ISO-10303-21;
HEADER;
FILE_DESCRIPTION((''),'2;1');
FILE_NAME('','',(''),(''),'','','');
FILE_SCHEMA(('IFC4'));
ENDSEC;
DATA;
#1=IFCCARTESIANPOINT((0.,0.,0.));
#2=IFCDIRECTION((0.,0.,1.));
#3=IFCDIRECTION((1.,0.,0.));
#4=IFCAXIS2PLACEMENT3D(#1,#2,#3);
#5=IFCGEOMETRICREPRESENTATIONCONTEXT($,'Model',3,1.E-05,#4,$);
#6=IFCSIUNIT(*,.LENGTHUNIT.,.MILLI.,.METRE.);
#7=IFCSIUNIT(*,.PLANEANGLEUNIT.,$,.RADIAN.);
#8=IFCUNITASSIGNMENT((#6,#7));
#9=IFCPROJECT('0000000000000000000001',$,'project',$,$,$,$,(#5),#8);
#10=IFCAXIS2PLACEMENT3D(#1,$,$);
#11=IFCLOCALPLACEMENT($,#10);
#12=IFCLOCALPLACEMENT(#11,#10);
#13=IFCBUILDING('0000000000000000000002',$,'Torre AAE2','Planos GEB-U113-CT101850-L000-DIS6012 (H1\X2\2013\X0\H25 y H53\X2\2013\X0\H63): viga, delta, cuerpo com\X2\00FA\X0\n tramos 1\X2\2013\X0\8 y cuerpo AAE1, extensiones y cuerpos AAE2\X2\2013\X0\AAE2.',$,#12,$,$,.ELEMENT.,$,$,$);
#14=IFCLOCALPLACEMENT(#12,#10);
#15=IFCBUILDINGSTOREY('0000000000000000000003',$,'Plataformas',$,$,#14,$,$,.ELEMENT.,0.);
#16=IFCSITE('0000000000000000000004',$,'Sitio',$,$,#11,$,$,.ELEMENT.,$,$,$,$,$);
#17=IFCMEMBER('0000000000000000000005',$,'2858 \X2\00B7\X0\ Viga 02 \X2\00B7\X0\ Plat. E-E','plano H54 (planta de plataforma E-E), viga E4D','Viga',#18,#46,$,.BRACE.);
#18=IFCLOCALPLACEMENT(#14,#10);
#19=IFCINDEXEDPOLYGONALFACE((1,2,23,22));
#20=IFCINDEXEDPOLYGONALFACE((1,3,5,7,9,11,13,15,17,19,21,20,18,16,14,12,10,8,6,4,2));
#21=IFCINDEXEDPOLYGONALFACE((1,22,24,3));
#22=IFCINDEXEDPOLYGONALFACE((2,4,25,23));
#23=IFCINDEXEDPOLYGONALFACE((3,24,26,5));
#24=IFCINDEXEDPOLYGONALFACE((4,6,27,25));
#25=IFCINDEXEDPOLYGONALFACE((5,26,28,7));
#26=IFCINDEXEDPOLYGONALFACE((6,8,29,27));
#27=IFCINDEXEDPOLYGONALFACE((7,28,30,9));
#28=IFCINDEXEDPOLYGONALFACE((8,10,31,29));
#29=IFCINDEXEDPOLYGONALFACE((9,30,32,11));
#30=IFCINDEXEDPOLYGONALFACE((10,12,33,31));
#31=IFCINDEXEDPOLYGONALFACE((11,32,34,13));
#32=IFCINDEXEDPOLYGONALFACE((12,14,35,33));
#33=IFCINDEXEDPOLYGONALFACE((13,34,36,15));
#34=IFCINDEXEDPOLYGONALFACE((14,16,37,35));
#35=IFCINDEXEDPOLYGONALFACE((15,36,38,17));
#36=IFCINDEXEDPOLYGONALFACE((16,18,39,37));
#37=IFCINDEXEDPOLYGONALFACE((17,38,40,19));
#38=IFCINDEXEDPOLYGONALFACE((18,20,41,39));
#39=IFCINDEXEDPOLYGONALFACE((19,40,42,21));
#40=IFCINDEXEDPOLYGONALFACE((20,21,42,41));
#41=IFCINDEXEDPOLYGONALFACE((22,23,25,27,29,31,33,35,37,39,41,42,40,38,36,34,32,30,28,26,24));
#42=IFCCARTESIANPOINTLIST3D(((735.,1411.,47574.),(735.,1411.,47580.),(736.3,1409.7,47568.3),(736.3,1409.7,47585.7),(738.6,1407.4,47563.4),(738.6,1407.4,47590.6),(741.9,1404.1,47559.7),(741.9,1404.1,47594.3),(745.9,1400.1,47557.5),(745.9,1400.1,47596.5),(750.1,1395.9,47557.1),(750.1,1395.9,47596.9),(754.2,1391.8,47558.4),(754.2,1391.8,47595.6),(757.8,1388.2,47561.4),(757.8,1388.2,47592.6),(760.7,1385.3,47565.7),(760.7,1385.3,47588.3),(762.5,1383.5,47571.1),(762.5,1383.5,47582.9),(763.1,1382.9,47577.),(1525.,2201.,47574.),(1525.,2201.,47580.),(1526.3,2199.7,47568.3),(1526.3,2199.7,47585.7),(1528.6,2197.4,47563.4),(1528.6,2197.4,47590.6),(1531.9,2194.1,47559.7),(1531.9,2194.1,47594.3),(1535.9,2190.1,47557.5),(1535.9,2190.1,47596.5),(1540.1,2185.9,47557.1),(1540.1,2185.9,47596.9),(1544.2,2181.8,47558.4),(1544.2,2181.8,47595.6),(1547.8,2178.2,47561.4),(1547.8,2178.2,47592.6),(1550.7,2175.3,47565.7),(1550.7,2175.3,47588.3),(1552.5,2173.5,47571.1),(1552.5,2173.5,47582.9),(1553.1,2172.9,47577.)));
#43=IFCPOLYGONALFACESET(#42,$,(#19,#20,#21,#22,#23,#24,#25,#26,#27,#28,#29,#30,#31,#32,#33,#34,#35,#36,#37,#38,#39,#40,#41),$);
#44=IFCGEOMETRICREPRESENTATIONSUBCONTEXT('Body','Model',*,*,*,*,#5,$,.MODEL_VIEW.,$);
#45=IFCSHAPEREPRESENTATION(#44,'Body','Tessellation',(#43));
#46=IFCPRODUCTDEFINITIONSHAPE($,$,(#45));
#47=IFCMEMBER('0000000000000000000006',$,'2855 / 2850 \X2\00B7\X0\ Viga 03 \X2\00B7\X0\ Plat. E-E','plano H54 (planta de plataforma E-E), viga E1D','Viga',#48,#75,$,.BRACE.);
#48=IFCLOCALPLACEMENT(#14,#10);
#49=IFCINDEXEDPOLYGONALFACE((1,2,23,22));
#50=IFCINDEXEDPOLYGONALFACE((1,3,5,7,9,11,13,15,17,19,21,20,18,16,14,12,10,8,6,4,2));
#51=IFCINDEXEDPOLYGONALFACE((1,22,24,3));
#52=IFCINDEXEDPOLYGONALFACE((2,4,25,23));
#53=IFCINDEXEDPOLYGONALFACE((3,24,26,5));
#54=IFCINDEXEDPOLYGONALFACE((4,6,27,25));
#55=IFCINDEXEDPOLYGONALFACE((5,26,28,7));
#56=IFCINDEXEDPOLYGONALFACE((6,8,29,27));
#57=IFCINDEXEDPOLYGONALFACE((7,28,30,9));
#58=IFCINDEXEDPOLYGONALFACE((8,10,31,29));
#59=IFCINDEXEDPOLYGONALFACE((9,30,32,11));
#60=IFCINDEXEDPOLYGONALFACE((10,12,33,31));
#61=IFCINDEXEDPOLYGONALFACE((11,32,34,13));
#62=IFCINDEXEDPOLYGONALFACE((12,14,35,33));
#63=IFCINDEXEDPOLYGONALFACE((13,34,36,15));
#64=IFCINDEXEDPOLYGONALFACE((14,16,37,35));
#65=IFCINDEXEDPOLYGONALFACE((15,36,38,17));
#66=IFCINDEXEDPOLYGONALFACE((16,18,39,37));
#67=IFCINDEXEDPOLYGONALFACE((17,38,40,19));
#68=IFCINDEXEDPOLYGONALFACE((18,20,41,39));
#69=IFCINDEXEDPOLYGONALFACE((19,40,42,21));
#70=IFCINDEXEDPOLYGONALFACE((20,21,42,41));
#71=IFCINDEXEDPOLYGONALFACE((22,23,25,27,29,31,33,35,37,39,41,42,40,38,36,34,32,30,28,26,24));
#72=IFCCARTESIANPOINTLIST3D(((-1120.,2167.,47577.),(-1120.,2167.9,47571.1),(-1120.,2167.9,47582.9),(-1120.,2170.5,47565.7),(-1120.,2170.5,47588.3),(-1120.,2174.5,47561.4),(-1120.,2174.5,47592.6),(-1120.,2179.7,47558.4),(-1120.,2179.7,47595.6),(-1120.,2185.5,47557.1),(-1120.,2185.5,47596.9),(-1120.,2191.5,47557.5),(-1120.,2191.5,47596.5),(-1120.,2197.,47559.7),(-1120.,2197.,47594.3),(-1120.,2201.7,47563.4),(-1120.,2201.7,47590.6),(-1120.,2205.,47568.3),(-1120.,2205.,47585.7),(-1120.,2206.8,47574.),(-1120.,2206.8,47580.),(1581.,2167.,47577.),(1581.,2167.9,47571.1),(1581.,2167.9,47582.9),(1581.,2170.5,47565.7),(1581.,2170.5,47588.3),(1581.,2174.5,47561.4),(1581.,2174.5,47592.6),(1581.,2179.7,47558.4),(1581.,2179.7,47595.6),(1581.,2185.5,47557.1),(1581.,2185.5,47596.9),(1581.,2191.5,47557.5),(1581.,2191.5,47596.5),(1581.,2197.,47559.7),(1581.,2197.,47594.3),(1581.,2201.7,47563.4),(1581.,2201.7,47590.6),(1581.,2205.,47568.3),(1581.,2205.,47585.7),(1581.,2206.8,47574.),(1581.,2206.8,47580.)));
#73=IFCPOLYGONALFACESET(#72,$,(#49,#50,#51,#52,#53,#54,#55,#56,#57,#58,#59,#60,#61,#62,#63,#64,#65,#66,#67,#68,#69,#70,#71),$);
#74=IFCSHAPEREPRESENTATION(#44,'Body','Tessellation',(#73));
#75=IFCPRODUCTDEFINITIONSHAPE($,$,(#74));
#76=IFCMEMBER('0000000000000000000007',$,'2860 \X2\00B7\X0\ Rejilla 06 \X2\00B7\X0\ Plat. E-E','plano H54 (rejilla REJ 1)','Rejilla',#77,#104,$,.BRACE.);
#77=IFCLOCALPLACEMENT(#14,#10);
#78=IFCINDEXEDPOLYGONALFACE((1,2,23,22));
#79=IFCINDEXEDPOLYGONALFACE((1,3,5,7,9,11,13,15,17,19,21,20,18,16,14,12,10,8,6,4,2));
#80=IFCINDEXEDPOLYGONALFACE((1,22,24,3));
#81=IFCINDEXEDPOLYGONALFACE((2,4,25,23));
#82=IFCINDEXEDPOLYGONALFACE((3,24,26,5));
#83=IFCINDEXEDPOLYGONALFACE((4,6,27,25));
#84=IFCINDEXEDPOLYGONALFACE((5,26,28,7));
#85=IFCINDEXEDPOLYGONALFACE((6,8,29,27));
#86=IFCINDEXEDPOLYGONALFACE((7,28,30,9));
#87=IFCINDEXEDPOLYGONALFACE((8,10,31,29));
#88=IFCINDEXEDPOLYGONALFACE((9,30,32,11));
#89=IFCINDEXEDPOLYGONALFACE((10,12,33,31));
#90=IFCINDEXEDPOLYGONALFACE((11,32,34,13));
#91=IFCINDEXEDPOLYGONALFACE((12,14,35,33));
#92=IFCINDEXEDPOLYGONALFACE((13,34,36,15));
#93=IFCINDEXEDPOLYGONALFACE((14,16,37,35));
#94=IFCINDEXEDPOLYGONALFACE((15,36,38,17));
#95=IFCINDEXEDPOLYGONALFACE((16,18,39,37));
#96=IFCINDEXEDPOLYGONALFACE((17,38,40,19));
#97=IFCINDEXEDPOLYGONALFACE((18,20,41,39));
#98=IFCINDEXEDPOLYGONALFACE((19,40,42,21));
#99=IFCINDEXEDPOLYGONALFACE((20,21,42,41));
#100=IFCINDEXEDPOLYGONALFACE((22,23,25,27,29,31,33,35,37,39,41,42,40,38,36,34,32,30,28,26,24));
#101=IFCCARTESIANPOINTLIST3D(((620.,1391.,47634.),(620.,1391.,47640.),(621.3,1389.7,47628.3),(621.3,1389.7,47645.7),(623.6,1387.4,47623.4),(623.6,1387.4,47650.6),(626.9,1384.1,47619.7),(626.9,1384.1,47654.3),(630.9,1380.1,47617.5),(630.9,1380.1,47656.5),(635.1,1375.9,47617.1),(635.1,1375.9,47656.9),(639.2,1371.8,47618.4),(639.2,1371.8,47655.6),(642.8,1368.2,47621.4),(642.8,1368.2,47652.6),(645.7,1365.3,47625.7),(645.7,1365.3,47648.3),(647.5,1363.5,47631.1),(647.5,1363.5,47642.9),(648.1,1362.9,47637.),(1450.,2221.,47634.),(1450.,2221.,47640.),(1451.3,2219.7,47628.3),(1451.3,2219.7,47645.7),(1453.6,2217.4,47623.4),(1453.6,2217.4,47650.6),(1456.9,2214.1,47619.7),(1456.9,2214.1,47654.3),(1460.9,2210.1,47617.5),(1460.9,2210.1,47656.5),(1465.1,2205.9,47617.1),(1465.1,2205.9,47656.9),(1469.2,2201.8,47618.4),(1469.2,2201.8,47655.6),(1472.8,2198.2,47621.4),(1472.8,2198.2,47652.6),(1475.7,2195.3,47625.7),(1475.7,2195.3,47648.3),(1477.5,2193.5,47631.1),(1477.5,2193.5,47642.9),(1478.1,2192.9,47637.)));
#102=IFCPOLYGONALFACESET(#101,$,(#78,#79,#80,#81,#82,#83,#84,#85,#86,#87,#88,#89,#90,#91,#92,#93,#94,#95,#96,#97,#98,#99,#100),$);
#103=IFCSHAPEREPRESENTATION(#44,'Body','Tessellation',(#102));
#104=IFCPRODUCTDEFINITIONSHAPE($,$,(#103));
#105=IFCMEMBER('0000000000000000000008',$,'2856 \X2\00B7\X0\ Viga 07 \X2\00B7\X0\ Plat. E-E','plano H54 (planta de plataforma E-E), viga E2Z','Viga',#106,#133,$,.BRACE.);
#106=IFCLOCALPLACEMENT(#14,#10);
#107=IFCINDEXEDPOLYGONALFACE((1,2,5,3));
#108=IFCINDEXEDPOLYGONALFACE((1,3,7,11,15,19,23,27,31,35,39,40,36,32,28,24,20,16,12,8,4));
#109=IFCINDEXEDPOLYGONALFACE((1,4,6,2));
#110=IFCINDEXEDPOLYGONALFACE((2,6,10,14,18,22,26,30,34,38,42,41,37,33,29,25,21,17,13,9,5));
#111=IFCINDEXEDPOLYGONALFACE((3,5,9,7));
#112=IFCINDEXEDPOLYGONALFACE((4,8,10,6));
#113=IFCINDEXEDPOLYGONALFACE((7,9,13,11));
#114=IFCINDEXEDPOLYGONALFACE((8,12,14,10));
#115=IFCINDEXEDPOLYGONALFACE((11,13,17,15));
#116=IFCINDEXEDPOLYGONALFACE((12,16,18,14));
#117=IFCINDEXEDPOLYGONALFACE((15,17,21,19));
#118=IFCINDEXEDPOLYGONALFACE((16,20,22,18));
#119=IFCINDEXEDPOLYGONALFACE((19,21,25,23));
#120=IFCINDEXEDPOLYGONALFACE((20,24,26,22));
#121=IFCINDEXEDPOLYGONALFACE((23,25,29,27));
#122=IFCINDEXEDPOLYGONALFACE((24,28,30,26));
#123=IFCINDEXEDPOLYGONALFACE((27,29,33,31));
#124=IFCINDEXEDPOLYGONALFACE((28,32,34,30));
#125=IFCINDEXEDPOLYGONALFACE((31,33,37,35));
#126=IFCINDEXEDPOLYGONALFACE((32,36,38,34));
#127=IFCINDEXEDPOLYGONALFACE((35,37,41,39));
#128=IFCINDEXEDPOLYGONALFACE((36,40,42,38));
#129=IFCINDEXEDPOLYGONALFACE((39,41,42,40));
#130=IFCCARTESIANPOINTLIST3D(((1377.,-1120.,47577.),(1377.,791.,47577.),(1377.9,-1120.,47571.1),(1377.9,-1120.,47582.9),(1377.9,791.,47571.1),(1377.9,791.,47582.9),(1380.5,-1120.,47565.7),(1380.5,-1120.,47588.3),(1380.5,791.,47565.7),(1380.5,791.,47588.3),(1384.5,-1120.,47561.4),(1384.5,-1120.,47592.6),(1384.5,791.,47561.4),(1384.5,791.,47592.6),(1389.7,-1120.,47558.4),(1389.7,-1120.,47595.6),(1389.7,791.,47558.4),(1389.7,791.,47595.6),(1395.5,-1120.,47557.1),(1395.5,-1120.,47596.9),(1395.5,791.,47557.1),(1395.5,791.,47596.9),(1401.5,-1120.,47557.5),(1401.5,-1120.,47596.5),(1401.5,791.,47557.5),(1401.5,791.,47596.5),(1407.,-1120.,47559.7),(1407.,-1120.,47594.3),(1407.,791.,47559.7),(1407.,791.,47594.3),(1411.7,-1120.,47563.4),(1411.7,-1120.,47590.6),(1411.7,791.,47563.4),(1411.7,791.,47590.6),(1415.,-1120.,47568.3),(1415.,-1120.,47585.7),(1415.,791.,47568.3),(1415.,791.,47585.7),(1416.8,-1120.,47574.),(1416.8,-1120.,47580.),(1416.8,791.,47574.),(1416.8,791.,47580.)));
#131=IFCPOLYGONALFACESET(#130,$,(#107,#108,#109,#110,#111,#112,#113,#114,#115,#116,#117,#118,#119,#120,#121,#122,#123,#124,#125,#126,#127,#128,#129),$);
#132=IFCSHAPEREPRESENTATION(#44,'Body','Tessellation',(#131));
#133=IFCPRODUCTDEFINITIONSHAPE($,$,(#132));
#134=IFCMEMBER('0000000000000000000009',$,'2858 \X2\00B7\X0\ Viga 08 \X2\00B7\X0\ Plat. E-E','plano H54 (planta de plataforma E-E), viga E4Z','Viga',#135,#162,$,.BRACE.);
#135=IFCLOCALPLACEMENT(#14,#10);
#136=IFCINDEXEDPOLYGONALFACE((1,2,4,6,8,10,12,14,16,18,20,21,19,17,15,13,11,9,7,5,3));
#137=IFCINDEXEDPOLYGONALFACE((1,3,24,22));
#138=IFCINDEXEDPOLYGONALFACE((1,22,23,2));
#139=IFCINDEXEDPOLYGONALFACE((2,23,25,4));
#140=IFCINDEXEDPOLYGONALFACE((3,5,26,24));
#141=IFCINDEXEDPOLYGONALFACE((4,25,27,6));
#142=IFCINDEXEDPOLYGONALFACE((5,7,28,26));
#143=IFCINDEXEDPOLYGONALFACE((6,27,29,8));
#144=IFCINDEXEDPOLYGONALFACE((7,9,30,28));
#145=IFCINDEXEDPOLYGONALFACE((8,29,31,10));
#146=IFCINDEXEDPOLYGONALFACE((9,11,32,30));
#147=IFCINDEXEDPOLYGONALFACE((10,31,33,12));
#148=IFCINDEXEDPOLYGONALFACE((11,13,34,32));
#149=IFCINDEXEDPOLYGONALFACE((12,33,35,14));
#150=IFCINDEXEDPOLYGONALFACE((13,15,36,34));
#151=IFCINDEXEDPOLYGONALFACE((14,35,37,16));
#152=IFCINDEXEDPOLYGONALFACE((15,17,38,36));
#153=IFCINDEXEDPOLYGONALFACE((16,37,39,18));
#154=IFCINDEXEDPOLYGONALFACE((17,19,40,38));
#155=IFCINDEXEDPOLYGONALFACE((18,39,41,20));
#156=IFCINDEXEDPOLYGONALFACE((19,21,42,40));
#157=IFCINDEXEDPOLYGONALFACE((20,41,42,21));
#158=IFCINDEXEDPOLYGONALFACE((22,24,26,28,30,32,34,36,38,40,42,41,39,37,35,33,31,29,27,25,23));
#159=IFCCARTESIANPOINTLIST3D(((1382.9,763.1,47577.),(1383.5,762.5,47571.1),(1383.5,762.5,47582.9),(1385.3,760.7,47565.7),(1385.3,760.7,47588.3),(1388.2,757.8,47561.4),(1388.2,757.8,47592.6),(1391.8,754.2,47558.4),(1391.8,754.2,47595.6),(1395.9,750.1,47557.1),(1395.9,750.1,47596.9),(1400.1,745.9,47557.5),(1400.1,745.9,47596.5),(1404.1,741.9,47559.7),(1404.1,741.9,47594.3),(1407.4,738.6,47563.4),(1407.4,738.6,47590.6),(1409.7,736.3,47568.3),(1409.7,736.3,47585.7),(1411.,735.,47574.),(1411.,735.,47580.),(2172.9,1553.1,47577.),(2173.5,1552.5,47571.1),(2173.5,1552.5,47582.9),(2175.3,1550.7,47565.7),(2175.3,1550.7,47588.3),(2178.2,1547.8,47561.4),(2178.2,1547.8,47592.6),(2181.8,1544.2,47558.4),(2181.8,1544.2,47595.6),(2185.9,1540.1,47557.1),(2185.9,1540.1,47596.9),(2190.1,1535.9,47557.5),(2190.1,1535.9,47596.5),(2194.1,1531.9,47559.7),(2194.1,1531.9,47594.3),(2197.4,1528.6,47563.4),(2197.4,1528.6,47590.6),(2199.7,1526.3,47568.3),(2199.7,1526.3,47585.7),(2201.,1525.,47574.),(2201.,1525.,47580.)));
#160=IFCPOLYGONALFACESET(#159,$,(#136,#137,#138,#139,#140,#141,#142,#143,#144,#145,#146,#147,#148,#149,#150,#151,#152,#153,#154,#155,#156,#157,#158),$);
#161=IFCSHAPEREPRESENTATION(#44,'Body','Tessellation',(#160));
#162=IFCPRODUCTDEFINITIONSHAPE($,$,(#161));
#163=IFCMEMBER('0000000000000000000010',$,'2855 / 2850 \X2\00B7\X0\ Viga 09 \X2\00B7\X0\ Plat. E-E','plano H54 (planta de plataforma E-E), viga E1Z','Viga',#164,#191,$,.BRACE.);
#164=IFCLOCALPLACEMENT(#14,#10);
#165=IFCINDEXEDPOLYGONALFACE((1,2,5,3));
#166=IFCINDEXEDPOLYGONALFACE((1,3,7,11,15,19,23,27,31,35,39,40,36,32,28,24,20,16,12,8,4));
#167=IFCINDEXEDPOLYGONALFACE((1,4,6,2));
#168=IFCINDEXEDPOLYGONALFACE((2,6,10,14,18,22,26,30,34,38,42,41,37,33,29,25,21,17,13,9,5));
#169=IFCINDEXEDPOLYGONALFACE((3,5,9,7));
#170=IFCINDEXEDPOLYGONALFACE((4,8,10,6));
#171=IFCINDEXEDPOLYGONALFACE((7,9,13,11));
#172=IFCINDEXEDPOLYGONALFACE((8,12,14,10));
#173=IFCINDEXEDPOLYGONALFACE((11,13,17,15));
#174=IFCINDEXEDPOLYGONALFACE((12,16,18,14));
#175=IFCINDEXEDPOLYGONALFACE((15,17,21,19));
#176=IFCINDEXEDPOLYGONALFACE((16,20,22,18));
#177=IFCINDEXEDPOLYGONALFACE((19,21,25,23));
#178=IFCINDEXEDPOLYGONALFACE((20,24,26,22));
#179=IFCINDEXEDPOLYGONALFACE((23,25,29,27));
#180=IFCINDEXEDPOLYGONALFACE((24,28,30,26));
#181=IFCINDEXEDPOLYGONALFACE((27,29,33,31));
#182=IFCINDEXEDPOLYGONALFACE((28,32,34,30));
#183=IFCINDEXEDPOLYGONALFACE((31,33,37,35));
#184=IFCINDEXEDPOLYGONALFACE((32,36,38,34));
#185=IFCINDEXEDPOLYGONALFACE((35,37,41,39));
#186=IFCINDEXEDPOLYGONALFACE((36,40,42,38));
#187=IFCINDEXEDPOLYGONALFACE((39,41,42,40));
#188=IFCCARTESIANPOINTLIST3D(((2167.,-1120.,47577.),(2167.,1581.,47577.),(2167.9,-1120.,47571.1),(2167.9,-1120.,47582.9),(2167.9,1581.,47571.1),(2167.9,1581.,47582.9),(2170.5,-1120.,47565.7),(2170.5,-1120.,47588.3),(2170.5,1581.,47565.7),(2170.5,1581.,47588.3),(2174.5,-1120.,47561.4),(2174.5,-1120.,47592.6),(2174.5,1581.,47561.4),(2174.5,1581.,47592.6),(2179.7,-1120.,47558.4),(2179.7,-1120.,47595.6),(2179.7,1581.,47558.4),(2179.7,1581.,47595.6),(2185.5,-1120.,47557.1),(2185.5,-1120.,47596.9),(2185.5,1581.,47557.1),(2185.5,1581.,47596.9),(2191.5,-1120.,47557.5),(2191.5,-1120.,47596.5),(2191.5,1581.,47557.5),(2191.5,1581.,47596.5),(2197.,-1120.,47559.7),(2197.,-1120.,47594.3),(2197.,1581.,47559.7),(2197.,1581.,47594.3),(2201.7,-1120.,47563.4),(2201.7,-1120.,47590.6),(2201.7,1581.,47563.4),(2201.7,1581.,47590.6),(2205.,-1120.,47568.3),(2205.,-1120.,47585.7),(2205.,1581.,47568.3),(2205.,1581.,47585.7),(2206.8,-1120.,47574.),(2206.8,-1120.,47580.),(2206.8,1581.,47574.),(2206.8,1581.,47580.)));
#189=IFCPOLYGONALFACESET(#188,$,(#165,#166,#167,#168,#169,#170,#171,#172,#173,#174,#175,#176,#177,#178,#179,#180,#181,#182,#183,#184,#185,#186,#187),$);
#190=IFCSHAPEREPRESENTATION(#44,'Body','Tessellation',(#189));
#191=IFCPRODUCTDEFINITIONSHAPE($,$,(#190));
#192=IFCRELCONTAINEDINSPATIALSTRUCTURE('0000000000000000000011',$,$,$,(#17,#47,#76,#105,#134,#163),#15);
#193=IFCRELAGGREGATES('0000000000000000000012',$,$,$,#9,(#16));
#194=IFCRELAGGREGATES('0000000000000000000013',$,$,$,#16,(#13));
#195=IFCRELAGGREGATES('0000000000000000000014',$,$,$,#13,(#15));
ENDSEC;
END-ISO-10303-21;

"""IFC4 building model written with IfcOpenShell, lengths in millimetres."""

from ifc_helpers import new_model, si_unit, frame, origin, origin_with_axes, place, context, subcontext, project, spatial, circle, extrude, element, save


model = new_model("IFC4")

# Units and contexts
model_context = context("Model", 3, precision=1e-05, world=origin_with_axes())
body_context = subcontext(model_context, "Body", "Model", "MODEL_VIEW")
ifc_project = project(units=[si_unit("LENGTHUNIT", "METRE", prefix="MILLI"), si_unit("PLANEANGLEUNIT", "RADIAN")], contexts=[model_context])

# Site, building, storey
site_placement = place(None, origin())
site = spatial("IfcSite", under=ifc_project, at=site_placement, Name="Sitio", CompositionType="ELEMENT")
building_placement = place(site_placement, origin())
building = spatial("IfcBuilding", under=site, at=building_placement, Name="Torre AAE2", Description="Planos GEB-U113-CT101850-L000-DIS6012 (H1–H25 y H53–H63): viga, delta, cuerpo común tramos 1–8 y cuerpo AAE1, extensiones y cuerpos AAE2–AAE2.", CompositionType="ELEMENT")
storey_placement = place(building_placement, origin())
storey = spatial("IfcBuildingStorey", under=building, at=storey_placement, Name="Plataformas", CompositionType="ELEMENT", Elevation=0.0)

# Members
member_1_placement = place(storey_placement, frame((1539.0, 2187.0, 47577.0), z_axis=(-0.707107, -0.707107, 0.0), x_axis=(0.707107, -0.707107, 0.0)))
element("IfcMember", 1, at=member_1_placement, inside=storey, Name="2858 · Viga 02 · Plat. E-E", Description="plano H54 (planta de plataforma E-E), viga E4D", ObjectType="Viga", PredefinedType="BRACE", context=body_context, shape_type="SweptSolid", body=[
    extrude(circle(Radius=20.0), None, (0.0, 0.0, 1.0), 1117.2),
])
member_2_placement = place(storey_placement, frame((1581.0, 2187.0, 47577.0), z_axis=(-1.0, 0.0, 0.0), x_axis=(0.0, -1.0, 0.0)))
element("IfcMember", 2, at=member_2_placement, inside=storey, Name="2855 / 2850 · Viga 03 · Plat. E-E", Description="plano H54 (planta de plataforma E-E), viga E1D", ObjectType="Viga", PredefinedType="BRACE", context=body_context, shape_type="SweptSolid", body=[
    extrude(circle(Radius=20.0), None, (0.0, 0.0, 1.0), 2701.0),
])
member_3_placement = place(storey_placement, frame((1464.0, 2207.0, 47637.0), z_axis=(-0.707107, -0.707107, 0.0), x_axis=(0.707107, -0.707107, 0.0)))
element("IfcMember", 3, at=member_3_placement, inside=storey, Name="2860 · Rejilla 06 · Plat. E-E", Description="plano H54 (rejilla REJ 1)", ObjectType="Rejilla", PredefinedType="BRACE", context=body_context, shape_type="SweptSolid", body=[
    extrude(circle(Radius=20.0), None, (0.0, 0.0, 1.0), 1173.8),
])
member_4_placement = place(storey_placement, frame((1397.0, -1120.0, 47577.0), z_axis=(0.0, 1.0, 0.0), x_axis=(-1.0, 0.0, 0.0)))
element("IfcMember", 4, at=member_4_placement, inside=storey, Name="2856 · Viga 07 · Plat. E-E", Description="plano H54 (planta de plataforma E-E), viga E2Z", ObjectType="Viga", PredefinedType="BRACE", context=body_context, shape_type="SweptSolid", body=[
    extrude(circle(Radius=20.0), None, (0.0, 0.0, 1.0), 1911.0),
])
member_5_placement = place(storey_placement, frame((2187.0, 1539.0, 47577.0), z_axis=(-0.707107, -0.707107, 0.0), x_axis=(-0.707107, 0.707107, 0.0)))
element("IfcMember", 5, at=member_5_placement, inside=storey, Name="2858 · Viga 08 · Plat. E-E", Description="plano H54 (planta de plataforma E-E), viga E4Z", ObjectType="Viga", PredefinedType="BRACE", context=body_context, shape_type="SweptSolid", body=[
    extrude(circle(Radius=20.0), None, (0.0, 0.0, 1.0), 1117.2),
])
member_6_placement = place(storey_placement, frame((2187.0, 1581.0, 47577.0), z_axis=(0.0, -1.0, 0.0), x_axis=(-1.0, 0.0, 0.0)))
element("IfcMember", 6, at=member_6_placement, inside=storey, Name="2855 / 2850 · Viga 09 · Plat. E-E", Description="plano H54 (planta de plataforma E-E), viga E1Z", ObjectType="Viga", PredefinedType="BRACE", context=body_context, shape_type="SweptSolid", body=[
    extrude(circle(Radius=20.0), None, (0.0, 0.0, 1.0), 2701.0),
])

save(model, "model.ifc")
